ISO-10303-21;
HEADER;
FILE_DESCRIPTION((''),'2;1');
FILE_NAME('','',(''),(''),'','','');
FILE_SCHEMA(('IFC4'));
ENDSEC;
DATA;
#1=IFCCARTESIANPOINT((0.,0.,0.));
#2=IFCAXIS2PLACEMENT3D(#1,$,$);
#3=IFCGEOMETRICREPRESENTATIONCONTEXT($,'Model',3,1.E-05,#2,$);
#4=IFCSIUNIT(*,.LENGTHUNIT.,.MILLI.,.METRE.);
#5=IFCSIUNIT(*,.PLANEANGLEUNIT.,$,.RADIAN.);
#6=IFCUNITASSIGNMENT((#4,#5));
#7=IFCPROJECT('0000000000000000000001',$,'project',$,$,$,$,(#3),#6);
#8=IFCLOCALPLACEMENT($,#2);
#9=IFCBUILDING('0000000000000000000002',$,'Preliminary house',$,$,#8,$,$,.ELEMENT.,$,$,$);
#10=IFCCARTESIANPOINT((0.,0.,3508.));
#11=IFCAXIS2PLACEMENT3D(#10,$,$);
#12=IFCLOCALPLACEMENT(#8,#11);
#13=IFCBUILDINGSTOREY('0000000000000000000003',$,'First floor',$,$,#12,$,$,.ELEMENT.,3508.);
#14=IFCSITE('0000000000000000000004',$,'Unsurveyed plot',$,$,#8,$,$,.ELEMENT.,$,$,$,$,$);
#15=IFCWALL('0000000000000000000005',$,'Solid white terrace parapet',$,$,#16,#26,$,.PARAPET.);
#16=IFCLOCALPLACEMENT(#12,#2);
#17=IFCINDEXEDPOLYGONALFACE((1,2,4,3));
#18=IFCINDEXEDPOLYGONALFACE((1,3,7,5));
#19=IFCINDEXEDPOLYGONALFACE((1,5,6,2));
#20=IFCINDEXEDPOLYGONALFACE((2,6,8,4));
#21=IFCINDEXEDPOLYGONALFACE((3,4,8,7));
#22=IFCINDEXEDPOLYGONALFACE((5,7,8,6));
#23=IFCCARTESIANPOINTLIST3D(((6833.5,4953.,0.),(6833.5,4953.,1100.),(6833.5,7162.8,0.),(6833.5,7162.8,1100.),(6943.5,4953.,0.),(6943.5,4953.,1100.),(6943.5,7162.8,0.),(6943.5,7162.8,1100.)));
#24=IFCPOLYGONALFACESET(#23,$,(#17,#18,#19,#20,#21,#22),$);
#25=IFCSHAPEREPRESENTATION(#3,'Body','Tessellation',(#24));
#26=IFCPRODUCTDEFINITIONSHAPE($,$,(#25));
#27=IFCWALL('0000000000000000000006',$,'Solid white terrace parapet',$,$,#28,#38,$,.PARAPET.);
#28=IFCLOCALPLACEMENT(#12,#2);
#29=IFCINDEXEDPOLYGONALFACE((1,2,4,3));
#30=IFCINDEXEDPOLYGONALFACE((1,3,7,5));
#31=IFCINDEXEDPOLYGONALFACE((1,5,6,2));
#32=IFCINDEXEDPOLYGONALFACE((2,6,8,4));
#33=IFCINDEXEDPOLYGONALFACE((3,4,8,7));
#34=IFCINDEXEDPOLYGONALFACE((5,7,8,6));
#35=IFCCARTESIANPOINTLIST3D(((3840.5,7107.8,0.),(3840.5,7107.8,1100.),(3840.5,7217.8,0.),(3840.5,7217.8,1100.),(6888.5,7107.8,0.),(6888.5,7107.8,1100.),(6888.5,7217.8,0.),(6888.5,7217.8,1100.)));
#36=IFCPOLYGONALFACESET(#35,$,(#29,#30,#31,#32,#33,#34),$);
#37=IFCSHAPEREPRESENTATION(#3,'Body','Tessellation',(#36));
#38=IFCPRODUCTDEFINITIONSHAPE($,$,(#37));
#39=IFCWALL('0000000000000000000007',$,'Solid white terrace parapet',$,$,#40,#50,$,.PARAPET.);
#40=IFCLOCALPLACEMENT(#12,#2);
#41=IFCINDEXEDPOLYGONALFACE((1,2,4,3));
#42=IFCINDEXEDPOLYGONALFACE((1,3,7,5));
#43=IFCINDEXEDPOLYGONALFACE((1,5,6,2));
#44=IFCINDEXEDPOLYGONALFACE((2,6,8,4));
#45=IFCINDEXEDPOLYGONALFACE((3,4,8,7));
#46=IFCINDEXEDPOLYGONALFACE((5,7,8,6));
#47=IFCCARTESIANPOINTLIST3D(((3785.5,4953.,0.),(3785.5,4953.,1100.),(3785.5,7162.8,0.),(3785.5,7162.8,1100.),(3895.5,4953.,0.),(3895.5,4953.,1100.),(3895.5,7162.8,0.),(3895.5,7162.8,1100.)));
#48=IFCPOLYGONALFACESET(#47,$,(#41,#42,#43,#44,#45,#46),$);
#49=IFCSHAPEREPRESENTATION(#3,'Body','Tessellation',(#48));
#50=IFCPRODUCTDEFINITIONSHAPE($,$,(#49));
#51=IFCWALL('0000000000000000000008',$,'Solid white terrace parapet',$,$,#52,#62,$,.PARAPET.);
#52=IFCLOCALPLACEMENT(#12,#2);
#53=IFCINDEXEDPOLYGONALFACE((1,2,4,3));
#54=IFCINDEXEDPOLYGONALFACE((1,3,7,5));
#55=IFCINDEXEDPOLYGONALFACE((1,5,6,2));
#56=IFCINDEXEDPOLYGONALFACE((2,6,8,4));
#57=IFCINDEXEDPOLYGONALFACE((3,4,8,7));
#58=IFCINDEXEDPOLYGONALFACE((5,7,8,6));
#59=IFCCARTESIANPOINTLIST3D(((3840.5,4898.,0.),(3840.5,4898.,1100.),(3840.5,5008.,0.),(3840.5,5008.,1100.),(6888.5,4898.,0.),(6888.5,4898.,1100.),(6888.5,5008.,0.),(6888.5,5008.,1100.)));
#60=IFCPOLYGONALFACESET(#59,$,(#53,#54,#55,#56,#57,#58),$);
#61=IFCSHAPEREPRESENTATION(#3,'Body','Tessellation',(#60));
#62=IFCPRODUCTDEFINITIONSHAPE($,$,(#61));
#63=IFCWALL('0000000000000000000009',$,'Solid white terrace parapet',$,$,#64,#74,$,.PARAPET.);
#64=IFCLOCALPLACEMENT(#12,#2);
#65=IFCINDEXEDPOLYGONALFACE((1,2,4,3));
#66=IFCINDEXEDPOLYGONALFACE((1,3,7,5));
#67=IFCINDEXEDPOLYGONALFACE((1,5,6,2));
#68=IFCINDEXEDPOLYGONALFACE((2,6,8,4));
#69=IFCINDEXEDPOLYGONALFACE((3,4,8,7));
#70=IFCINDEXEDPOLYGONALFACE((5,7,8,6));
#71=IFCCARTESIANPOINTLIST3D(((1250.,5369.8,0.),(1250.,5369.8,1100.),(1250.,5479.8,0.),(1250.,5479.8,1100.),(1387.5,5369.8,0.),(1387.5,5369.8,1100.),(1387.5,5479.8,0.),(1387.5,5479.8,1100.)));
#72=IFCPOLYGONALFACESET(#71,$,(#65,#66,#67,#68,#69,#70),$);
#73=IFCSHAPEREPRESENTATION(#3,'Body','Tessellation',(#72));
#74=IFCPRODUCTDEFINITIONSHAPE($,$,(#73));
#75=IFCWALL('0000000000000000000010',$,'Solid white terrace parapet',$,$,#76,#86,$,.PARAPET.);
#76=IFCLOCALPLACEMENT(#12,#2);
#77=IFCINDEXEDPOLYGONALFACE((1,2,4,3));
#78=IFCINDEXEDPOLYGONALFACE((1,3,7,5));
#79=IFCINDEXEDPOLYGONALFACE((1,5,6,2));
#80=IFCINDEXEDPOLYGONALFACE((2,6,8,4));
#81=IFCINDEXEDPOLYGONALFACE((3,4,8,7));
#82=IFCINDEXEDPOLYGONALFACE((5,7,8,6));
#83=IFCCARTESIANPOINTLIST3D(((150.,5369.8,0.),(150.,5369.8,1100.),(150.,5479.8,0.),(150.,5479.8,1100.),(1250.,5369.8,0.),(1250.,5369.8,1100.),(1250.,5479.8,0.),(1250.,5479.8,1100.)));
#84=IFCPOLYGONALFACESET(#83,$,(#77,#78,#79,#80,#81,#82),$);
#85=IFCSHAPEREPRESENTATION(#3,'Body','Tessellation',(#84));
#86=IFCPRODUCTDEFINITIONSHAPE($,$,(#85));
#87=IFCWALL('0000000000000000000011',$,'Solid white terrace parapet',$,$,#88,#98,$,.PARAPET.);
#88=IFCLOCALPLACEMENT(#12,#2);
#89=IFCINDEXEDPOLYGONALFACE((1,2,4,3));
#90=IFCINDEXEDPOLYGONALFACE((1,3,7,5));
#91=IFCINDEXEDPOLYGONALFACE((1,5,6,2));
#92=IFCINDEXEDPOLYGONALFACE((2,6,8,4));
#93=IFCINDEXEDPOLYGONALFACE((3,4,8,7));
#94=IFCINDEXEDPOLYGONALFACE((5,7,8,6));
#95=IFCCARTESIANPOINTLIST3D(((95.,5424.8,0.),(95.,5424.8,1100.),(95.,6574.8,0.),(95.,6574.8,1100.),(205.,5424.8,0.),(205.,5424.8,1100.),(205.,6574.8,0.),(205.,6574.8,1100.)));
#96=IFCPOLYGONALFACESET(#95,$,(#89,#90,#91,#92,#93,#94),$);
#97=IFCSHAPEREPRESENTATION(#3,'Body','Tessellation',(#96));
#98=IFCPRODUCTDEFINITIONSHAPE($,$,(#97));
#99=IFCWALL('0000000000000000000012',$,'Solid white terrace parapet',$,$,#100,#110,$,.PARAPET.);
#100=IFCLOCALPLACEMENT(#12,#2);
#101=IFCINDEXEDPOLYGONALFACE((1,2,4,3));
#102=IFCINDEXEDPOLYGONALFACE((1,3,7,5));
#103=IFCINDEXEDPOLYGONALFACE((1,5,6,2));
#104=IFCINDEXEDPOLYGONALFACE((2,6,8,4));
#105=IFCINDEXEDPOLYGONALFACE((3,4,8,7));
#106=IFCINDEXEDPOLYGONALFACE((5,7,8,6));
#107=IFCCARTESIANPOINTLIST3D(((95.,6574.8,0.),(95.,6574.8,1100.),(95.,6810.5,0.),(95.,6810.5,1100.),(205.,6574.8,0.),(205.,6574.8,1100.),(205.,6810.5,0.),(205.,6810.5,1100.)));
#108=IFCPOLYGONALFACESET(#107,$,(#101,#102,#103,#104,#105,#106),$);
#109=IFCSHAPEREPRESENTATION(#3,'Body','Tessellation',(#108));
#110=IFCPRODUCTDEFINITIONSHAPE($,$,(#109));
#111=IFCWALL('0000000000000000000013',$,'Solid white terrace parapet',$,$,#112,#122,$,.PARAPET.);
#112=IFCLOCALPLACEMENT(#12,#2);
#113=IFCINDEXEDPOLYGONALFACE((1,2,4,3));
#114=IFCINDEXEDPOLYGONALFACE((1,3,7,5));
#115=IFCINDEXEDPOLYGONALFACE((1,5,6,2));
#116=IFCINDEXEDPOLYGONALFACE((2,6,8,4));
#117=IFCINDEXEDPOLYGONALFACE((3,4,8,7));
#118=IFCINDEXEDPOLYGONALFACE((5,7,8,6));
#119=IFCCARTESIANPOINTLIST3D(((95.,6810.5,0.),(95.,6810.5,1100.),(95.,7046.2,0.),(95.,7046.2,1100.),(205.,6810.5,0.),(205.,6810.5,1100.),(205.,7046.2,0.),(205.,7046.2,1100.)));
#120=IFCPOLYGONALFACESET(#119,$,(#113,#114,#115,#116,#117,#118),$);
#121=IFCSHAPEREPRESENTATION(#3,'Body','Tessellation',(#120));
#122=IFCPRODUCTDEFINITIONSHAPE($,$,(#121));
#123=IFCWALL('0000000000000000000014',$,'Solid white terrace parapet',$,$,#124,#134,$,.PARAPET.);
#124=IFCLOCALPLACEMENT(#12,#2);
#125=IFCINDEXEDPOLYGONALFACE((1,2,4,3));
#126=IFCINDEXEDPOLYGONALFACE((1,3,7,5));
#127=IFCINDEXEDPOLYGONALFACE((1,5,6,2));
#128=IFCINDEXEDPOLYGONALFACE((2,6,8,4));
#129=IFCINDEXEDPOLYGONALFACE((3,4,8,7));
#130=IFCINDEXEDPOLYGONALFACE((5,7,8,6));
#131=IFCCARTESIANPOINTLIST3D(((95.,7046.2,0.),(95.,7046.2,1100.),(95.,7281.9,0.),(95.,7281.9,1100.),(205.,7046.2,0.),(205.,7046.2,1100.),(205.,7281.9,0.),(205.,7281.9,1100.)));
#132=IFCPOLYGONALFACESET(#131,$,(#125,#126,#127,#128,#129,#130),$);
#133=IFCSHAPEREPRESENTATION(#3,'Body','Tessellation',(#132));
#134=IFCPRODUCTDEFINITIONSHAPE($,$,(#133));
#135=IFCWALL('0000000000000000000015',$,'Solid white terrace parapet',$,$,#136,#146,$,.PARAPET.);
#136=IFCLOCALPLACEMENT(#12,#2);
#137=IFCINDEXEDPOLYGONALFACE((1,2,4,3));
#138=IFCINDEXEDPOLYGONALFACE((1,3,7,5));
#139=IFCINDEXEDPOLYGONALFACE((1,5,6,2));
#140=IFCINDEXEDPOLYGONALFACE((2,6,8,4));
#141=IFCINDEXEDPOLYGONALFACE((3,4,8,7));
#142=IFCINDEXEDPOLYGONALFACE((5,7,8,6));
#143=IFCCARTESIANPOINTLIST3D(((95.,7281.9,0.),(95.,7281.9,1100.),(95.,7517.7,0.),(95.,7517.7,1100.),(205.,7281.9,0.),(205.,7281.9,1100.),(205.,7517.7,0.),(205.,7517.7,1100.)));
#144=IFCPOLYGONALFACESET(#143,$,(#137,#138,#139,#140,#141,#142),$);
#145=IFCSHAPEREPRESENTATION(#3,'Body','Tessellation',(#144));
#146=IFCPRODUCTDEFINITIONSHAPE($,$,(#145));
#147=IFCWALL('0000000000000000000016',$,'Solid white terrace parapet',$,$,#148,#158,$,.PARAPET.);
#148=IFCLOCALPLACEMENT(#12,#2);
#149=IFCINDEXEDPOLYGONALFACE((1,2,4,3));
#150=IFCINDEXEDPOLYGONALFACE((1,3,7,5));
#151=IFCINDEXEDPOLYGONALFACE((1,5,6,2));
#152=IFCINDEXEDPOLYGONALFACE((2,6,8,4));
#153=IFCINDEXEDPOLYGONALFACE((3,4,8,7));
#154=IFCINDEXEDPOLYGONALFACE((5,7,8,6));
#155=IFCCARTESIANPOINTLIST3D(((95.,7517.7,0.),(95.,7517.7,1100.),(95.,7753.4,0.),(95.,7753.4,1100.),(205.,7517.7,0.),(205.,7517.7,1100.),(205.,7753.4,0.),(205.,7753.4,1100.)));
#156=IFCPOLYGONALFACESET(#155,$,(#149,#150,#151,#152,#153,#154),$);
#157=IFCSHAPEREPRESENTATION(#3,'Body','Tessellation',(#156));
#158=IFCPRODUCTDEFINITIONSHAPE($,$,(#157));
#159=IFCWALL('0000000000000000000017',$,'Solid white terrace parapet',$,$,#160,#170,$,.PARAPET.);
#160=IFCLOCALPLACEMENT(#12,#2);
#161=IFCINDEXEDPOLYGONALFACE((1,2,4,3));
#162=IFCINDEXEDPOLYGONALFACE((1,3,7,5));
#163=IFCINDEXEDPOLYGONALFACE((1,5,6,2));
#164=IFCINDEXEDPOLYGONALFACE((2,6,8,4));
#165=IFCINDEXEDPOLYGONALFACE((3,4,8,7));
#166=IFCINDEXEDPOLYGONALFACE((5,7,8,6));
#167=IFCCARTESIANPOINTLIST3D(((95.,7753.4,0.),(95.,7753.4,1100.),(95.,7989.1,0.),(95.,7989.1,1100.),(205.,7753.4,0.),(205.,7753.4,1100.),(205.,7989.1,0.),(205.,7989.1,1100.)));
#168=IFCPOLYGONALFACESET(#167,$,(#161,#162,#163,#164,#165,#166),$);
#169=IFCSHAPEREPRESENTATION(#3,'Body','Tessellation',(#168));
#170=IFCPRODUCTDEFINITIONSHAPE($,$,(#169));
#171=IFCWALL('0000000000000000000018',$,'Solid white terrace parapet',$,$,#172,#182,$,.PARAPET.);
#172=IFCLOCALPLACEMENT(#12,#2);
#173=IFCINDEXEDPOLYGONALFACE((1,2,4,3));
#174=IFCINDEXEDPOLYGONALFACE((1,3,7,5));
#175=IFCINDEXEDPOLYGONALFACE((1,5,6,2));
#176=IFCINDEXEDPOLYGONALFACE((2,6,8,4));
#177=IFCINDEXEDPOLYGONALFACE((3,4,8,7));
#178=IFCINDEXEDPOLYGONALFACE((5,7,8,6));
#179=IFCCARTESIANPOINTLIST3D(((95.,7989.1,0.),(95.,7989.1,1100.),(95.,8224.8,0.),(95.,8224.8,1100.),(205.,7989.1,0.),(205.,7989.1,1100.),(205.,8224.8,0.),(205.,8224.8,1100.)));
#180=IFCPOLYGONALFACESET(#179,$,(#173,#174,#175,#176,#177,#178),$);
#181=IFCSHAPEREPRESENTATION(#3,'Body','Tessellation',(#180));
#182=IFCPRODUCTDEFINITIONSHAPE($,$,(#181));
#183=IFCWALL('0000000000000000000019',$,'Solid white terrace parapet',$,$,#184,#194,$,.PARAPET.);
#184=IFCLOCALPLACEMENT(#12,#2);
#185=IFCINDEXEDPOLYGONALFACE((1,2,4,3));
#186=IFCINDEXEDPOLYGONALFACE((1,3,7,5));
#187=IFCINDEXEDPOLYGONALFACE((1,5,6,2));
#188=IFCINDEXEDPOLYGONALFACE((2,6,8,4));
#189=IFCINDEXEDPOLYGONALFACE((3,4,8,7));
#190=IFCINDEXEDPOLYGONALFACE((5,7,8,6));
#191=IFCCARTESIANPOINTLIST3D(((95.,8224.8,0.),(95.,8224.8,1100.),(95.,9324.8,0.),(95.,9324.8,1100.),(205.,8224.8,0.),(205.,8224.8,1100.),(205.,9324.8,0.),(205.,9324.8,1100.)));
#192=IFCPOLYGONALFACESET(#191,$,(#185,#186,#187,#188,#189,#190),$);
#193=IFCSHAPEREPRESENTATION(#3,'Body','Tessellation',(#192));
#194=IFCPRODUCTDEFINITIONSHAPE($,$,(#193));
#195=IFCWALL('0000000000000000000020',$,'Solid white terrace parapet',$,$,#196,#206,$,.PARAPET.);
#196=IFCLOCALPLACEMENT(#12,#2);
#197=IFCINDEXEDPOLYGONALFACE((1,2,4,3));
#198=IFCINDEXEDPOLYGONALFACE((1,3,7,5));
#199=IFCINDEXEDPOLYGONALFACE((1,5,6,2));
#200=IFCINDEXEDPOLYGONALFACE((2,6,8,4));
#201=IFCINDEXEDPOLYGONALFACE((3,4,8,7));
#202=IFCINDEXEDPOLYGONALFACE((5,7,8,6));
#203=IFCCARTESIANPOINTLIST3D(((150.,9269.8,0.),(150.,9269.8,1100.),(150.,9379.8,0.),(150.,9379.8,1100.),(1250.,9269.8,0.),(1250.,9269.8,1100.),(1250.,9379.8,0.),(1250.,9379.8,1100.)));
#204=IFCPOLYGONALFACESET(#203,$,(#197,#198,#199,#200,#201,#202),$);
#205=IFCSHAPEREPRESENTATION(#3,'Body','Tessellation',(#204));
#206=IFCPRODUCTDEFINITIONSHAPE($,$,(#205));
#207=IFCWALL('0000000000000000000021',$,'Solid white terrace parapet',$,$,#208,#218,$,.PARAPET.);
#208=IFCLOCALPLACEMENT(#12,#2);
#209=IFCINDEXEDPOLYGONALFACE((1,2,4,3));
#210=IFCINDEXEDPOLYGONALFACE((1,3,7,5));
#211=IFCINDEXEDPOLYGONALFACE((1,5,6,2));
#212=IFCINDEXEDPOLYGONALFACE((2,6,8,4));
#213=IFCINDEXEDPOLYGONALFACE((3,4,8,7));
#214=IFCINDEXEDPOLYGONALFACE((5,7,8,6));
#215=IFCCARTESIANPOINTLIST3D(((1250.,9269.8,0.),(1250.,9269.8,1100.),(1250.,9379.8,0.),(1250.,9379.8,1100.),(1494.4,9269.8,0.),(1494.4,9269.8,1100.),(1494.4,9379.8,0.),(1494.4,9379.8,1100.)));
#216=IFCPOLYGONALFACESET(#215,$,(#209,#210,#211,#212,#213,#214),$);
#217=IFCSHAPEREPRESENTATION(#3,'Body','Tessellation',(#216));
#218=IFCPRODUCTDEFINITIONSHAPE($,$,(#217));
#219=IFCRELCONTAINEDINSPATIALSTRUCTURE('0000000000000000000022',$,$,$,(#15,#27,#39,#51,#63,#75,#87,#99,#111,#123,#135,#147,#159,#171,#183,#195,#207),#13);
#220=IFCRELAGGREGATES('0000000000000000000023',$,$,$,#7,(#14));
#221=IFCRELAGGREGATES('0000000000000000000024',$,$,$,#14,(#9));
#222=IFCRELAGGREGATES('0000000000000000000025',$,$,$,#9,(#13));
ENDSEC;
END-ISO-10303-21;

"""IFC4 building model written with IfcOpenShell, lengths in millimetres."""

from ifc_helpers import new_model, si_unit, frame, origin, place, context, project, spatial, polyline, outline, extrude, element, save


model = new_model("IFC4")

# Units and contexts
model_context = context("Model", 3, precision=1e-05, world=origin())
ifc_project = project(units=[si_unit("LENGTHUNIT", "METRE", prefix="MILLI"), si_unit("PLANEANGLEUNIT", "RADIAN")], contexts=[model_context])

# Site, building, storey
placement_1 = place(None, origin())
site = spatial("IfcSite", under=ifc_project, at=placement_1, Name="Unsurveyed plot", CompositionType="ELEMENT")
building = spatial("IfcBuilding", under=site, at=placement_1, Name="Preliminary house", CompositionType="ELEMENT")
placement_2 = place(placement_1, frame((0.0, 0.0, 3508.0)))
storey = spatial("IfcBuildingStorey", under=building, at=placement_2, Name="First floor", CompositionType="ELEMENT", Elevation=3508.0)

# Walls
element("IfcWall", 1, at=placement_2, inside=storey, Name="Solid white terrace parapet", PredefinedType="PARAPET", context=model_context, shape_type="SweptSolid", body=[
    extrude(outline(polyline([(6833.5, 7162.8), (6943.5, 7162.8), (6943.5, 4953.0), (6833.5, 4953.0), (6833.5, 7162.8)])), origin(), (0.0, 0.0, 1.0), 1100.0),
])
element("IfcWall", 2, at=placement_2, inside=storey, Name="Solid white terrace parapet", PredefinedType="PARAPET", context=model_context, shape_type="SweptSolid", body=[
    extrude(outline(polyline([(3840.5, 7107.8), (3840.5, 7217.8), (6888.5, 7217.8), (6888.5, 7107.8), (3840.5, 7107.8)])), origin(), (0.0, 0.0, 1.0), 1100.0),
])
element("IfcWall", 3, at=placement_2, inside=storey, Name="Solid white terrace parapet", PredefinedType="PARAPET", context=model_context, shape_type="SweptSolid", body=[
    extrude(outline(polyline([(3895.5, 4953.0), (3785.5, 4953.0), (3785.5, 7162.8), (3895.5, 7162.8), (3895.5, 4953.0)])), origin(), (0.0, 0.0, 1.0), 1100.0),
])
element("IfcWall", 4, at=placement_2, inside=storey, Name="Solid white terrace parapet", PredefinedType="PARAPET", context=model_context, shape_type="SweptSolid", body=[
    extrude(outline(polyline([(6888.5, 5008.0), (6888.5, 4898.0), (3840.5, 4898.0), (3840.5, 5008.0), (6888.5, 5008.0)])), origin(), (0.0, 0.0, 1.0), 1100.0),
])
element("IfcWall", 5, at=placement_2, inside=storey, Name="Solid white terrace parapet", PredefinedType="PARAPET", context=model_context, shape_type="SweptSolid", body=[
    extrude(outline(polyline([(1250.0, 5369.8), (1250.0, 5479.8), (1387.5, 5479.8), (1387.5, 5369.8), (1250.0, 5369.8)])), origin(), (0.0, 0.0, 1.0), 1100.0),
])
element("IfcWall", 6, at=placement_2, inside=storey, Name="Solid white terrace parapet", PredefinedType="PARAPET", context=model_context, shape_type="SweptSolid", body=[
    extrude(outline(polyline([(150.0, 5369.8), (150.0, 5479.8), (1250.0, 5479.8), (1250.0, 5369.8), (150.0, 5369.8)])), origin(), (0.0, 0.0, 1.0), 1100.0),
])
element("IfcWall", 7, at=placement_2, inside=storey, Name="Solid white terrace parapet", PredefinedType="PARAPET", context=model_context, shape_type="SweptSolid", body=[
    extrude(outline(polyline([(95.0, 6574.8), (205.0, 6574.8), (205.0, 5424.8), (95.0, 5424.8), (95.0, 6574.8)])), origin(), (0.0, 0.0, 1.0), 1100.0),
])
element("IfcWall", 8, at=placement_2, inside=storey, Name="Solid white terrace parapet", PredefinedType="PARAPET", context=model_context, shape_type="SweptSolid", body=[
    extrude(outline(polyline([(95.0, 6810.5), (205.0, 6810.5), (205.0, 6574.8), (95.0, 6574.8), (95.0, 6810.5)])), origin(), (0.0, 0.0, 1.0), 1100.0),
])
element("IfcWall", 9, at=placement_2, inside=storey, Name="Solid white terrace parapet", PredefinedType="PARAPET", context=model_context, shape_type="SweptSolid", body=[
    extrude(outline(polyline([(95.0, 7046.2), (205.0, 7046.2), (205.0, 6810.5), (95.0, 6810.5), (95.0, 7046.2)])), origin(), (0.0, 0.0, 1.0), 1100.0),
])
element("IfcWall", 10, at=placement_2, inside=storey, Name="Solid white terrace parapet", PredefinedType="PARAPET", context=model_context, shape_type="SweptSolid", body=[
    extrude(outline(polyline([(95.0, 7281.9), (205.0, 7281.9), (205.0, 7046.2), (95.0, 7046.2), (95.0, 7281.9)])), origin(), (0.0, 0.0, 1.0), 1100.0),
])
element("IfcWall", 11, at=placement_2, inside=storey, Name="Solid white terrace parapet", PredefinedType="PARAPET", context=model_context, shape_type="SweptSolid", body=[
    extrude(outline(polyline([(95.0, 7517.7), (205.0, 7517.7), (205.0, 7281.9), (95.0, 7281.9), (95.0, 7517.7)])), origin(), (0.0, 0.0, 1.0), 1100.0),
])
element("IfcWall", 12, at=placement_2, inside=storey, Name="Solid white terrace parapet", PredefinedType="PARAPET", context=model_context, shape_type="SweptSolid", body=[
    extrude(outline(polyline([(95.0, 7753.4), (205.0, 7753.4), (205.0, 7517.7), (95.0, 7517.7), (95.0, 7753.4)])), origin(), (0.0, 0.0, 1.0), 1100.0),
])
element("IfcWall", 13, at=placement_2, inside=storey, Name="Solid white terrace parapet", PredefinedType="PARAPET", context=model_context, shape_type="SweptSolid", body=[
    extrude(outline(polyline([(95.0, 7989.1), (205.0, 7989.1), (205.0, 7753.4), (95.0, 7753.4), (95.0, 7989.1)])), origin(), (0.0, 0.0, 1.0), 1100.0),
])
element("IfcWall", 14, at=placement_2, inside=storey, Name="Solid white terrace parapet", PredefinedType="PARAPET", context=model_context, shape_type="SweptSolid", body=[
    extrude(outline(polyline([(95.0, 8224.8), (205.0, 8224.8), (205.0, 7989.1), (95.0, 7989.1), (95.0, 8224.8)])), origin(), (0.0, 0.0, 1.0), 1100.0),
])
element("IfcWall", 15, at=placement_2, inside=storey, Name="Solid white terrace parapet", PredefinedType="PARAPET", context=model_context, shape_type="SweptSolid", body=[
    extrude(outline(polyline([(95.0, 9324.8), (205.0, 9324.8), (205.0, 8224.8), (95.0, 8224.8), (95.0, 9324.8)])), origin(), (0.0, 0.0, 1.0), 1100.0),
])
element("IfcWall", 16, at=placement_2, inside=storey, Name="Solid white terrace parapet", PredefinedType="PARAPET", context=model_context, shape_type="SweptSolid", body=[
    extrude(outline(polyline([(1250.0, 9379.8), (1250.0, 9269.8), (150.0, 9269.8), (150.0, 9379.8), (1250.0, 9379.8)])), origin(), (0.0, 0.0, 1.0), 1100.0),
])
element("IfcWall", 17, at=placement_2, inside=storey, Name="Solid white terrace parapet", PredefinedType="PARAPET", context=model_context, shape_type="SweptSolid", body=[
    extrude(outline(polyline([(1494.4, 9379.8), (1494.4, 9269.8), (1250.0, 9269.8), (1250.0, 9379.8), (1494.4, 9379.8)])), origin(), (0.0, 0.0, 1.0), 1100.0),
])

save(model, "model.ifc")
